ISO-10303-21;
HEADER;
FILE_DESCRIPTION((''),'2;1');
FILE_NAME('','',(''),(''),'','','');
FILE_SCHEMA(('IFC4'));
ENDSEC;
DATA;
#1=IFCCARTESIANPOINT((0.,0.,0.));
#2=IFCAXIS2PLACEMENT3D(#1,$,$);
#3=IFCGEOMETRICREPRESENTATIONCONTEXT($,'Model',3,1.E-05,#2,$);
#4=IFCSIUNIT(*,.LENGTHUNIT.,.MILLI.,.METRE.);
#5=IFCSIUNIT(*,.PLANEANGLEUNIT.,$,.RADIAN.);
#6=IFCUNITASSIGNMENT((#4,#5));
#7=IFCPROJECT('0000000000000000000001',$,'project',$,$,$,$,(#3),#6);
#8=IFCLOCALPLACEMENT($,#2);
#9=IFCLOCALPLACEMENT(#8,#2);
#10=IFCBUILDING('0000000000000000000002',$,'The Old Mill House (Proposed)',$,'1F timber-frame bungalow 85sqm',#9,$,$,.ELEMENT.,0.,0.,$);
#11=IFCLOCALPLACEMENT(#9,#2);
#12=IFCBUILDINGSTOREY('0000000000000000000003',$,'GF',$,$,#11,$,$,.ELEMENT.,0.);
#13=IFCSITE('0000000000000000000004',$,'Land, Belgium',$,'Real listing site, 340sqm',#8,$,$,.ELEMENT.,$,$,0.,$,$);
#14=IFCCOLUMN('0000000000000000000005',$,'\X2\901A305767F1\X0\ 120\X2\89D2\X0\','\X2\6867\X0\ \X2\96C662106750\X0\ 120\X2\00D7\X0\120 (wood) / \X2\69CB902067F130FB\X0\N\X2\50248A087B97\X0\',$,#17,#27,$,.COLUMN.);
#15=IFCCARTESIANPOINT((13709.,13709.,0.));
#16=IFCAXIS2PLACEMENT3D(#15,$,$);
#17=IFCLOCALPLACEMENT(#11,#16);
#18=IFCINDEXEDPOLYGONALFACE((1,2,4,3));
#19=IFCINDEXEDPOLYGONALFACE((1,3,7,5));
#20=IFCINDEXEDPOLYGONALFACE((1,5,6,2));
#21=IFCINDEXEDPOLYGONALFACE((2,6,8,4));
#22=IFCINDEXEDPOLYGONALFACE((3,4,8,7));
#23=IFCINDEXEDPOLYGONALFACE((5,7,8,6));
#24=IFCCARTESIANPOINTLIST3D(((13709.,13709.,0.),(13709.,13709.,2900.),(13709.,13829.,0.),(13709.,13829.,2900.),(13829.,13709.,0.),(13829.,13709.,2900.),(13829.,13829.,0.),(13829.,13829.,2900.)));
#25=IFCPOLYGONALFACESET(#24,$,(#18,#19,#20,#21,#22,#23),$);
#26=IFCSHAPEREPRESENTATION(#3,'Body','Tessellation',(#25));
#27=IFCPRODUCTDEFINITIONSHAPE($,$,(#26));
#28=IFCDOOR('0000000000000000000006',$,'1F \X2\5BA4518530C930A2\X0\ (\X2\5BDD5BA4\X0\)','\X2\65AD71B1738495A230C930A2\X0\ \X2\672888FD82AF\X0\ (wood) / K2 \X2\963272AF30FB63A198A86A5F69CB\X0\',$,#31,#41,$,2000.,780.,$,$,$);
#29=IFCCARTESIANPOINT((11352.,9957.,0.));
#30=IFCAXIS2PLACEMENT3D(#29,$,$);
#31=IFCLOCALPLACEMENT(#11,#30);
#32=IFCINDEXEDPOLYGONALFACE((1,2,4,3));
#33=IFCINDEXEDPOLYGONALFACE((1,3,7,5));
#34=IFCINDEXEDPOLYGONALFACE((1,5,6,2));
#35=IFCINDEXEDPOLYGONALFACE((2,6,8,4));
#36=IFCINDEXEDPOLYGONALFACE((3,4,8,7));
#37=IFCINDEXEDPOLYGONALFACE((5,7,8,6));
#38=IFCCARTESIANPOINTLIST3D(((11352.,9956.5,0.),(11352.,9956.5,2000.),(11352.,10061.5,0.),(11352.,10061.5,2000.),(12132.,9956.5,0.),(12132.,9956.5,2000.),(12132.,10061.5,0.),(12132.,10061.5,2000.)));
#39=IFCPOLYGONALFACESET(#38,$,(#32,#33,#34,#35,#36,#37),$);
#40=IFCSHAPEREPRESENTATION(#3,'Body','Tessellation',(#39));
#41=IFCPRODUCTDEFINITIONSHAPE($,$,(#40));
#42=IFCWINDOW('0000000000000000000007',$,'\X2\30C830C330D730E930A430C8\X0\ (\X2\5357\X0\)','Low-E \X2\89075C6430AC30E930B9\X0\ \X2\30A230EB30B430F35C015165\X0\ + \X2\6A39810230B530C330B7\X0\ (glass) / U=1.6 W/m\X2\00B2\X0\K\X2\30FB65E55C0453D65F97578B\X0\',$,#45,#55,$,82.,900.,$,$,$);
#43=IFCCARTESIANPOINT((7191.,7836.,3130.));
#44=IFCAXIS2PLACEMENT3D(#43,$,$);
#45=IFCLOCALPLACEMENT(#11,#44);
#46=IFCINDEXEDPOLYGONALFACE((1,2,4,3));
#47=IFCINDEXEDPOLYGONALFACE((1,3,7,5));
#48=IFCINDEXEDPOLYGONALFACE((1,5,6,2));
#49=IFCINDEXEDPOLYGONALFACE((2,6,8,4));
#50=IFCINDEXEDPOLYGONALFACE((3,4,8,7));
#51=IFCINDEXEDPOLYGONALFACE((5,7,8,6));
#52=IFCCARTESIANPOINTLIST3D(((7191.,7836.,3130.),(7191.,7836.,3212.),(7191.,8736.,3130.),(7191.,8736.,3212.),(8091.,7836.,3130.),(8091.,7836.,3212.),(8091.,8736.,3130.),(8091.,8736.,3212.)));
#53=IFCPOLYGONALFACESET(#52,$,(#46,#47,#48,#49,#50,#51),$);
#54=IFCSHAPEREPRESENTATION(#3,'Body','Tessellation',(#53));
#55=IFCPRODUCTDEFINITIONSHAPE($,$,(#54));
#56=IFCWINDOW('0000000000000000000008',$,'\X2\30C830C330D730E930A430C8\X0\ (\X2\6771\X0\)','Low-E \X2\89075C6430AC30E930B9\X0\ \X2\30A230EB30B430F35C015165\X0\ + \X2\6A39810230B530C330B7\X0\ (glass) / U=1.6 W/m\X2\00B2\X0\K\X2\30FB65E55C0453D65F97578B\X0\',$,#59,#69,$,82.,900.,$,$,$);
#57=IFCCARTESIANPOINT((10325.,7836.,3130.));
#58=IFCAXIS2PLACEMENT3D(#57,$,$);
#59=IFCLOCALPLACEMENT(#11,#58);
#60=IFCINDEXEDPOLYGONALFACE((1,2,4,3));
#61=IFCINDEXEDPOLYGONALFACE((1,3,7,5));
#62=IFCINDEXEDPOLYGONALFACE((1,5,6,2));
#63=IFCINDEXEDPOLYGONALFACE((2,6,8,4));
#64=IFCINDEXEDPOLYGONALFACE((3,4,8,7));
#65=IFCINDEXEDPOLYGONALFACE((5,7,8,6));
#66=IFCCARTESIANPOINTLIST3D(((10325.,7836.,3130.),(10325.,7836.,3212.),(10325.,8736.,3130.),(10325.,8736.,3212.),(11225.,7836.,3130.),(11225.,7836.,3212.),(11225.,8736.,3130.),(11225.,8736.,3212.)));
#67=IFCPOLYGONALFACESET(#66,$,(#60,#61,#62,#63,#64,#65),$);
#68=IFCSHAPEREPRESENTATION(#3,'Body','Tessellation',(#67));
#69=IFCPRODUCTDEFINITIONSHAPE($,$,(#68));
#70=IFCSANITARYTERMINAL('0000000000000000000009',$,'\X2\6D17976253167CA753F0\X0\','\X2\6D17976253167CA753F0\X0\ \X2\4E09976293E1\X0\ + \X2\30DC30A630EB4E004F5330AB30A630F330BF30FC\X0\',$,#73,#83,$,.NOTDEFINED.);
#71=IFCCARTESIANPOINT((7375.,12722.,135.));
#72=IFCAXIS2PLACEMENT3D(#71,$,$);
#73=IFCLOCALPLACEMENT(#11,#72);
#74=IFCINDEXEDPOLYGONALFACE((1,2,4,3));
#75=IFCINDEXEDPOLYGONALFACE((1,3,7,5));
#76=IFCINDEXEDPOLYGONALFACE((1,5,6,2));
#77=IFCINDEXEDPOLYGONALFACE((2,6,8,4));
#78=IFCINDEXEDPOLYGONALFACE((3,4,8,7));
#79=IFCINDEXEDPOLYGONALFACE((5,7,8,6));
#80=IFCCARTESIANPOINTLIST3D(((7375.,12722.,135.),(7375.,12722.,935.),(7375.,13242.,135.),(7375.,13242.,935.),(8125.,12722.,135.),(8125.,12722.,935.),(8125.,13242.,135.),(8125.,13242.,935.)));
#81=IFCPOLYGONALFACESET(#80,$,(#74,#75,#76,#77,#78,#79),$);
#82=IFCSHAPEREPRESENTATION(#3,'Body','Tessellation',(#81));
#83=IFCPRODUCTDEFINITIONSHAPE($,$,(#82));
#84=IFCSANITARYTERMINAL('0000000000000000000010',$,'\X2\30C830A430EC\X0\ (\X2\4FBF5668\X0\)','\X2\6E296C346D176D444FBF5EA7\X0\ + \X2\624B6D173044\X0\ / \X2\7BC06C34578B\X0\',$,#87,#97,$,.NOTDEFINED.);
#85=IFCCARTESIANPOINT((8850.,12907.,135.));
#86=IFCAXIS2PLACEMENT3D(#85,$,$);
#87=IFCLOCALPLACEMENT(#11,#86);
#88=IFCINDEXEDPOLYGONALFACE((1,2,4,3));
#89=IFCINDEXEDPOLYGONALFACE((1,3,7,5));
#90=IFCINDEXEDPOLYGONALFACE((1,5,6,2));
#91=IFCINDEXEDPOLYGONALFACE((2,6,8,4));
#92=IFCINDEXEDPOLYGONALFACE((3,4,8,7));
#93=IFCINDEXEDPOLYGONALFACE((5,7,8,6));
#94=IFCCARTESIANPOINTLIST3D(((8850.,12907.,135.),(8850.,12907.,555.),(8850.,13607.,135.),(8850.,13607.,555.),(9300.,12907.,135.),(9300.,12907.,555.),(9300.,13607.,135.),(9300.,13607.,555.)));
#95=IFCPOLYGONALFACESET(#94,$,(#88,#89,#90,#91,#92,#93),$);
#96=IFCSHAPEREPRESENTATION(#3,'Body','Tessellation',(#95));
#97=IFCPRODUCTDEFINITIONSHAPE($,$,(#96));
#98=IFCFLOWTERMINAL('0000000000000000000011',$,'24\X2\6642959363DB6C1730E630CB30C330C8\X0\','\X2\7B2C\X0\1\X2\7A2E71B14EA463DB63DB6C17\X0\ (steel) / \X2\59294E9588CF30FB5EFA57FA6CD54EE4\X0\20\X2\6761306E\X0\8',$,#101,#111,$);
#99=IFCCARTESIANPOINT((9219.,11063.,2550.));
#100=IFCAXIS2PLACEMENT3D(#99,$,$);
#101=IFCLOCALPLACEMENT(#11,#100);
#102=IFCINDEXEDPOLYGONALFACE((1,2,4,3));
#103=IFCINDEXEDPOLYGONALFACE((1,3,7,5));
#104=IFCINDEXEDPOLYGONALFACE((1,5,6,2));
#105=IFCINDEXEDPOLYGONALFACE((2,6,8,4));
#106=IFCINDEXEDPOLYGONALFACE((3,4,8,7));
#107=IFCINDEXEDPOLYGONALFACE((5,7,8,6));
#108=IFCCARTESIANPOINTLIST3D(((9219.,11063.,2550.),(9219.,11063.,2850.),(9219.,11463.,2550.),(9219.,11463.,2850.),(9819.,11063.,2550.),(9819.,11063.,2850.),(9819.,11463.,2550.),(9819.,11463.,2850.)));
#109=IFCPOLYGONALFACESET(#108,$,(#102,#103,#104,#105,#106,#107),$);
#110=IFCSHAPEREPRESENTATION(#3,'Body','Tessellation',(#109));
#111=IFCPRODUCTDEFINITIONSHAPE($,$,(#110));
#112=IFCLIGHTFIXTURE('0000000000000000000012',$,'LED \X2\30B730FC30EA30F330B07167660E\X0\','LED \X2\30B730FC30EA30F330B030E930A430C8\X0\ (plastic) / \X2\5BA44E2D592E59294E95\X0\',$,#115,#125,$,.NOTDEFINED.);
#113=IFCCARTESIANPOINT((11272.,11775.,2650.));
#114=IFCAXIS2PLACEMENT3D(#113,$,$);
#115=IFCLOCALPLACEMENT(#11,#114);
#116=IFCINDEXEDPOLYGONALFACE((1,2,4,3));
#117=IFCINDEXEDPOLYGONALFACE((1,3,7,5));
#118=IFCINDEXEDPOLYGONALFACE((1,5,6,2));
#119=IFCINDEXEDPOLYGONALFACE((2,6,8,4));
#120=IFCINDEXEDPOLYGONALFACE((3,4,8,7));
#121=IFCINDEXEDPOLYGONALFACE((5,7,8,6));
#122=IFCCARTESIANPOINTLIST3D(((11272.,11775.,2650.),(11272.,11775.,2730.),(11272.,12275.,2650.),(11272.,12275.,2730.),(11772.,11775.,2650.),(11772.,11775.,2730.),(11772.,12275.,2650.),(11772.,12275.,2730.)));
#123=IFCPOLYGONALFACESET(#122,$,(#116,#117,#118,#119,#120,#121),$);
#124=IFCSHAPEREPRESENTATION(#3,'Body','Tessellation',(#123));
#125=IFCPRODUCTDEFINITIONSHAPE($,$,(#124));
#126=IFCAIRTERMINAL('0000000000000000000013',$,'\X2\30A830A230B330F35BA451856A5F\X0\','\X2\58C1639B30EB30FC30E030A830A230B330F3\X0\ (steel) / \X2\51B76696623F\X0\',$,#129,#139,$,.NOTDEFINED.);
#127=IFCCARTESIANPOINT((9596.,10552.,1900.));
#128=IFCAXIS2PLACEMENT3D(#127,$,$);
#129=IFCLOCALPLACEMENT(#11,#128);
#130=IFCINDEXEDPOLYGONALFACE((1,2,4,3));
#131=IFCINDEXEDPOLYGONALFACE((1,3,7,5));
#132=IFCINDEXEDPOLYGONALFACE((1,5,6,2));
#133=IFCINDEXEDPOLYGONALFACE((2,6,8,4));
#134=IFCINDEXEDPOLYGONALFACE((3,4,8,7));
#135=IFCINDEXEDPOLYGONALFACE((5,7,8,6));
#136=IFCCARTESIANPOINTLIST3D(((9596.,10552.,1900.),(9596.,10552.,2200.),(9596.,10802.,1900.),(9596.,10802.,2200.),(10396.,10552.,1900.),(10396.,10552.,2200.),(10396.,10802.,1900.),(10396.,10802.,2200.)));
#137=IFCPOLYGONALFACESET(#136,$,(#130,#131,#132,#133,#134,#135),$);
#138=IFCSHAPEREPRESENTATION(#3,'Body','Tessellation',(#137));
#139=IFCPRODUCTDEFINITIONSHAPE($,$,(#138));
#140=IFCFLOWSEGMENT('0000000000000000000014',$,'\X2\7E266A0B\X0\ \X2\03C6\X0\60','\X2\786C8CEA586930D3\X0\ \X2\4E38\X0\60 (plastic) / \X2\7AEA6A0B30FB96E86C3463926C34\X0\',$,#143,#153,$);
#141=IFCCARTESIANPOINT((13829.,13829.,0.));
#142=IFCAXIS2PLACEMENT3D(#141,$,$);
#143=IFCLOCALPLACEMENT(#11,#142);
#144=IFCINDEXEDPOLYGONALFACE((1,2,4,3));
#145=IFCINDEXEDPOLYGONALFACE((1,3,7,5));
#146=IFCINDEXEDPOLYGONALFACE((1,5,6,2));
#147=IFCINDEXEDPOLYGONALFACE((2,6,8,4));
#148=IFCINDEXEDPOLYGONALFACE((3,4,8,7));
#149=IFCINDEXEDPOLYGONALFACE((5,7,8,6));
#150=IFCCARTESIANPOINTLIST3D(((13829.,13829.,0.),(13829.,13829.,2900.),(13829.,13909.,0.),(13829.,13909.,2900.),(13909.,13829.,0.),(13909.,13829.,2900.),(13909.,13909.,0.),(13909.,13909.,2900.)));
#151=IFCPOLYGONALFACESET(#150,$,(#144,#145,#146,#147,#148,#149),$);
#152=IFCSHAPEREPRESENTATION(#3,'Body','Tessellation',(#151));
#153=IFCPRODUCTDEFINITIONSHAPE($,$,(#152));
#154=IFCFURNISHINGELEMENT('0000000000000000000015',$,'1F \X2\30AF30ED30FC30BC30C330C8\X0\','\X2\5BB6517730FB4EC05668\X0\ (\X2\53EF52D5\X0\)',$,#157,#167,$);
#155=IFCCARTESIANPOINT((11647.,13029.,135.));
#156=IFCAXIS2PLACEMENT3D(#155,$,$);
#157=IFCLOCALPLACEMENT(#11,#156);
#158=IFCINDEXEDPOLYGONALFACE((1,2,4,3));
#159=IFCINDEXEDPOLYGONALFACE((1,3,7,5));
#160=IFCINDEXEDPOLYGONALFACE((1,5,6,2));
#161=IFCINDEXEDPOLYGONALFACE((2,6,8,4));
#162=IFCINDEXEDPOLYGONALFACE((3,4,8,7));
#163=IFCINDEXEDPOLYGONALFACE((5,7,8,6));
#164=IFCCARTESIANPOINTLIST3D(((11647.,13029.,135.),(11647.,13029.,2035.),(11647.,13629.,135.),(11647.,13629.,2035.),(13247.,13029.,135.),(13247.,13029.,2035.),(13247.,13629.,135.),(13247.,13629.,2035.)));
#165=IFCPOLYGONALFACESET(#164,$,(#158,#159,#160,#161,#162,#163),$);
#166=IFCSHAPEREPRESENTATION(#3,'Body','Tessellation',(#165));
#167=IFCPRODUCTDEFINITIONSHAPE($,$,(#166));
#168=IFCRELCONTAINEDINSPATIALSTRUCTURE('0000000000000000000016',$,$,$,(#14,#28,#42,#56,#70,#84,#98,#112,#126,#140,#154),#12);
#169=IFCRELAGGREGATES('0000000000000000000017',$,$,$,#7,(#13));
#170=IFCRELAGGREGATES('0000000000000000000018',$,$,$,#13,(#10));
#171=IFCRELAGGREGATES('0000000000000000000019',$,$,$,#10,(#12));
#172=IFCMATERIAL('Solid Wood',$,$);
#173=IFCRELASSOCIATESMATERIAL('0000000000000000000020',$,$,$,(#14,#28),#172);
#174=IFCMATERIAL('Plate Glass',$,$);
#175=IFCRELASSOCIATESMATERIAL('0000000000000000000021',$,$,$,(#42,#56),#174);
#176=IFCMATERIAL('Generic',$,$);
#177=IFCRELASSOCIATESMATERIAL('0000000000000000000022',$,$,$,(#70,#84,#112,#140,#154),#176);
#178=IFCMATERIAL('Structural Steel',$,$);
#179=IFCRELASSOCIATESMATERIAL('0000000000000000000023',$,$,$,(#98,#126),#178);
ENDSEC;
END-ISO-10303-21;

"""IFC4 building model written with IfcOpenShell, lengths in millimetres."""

from ifc_helpers import new_model, si_unit, frame, frame_2d, origin, place, context, project, spatial, rectangle, extrude, material, element, save


model = new_model("IFC4")

# Units and contexts
model_context = context("Model", 3, precision=1e-05, world=origin())
ifc_project = project(units=[si_unit("LENGTHUNIT", "METRE", prefix="MILLI"), si_unit("PLANEANGLEUNIT", "RADIAN")], contexts=[model_context])

# Site, building, storey
site_placement = place(None, origin())
site = spatial("IfcSite", under=ifc_project, at=site_placement, Name="Land, Belgium", ObjectType="Real listing site, 340sqm", CompositionType="ELEMENT", RefElevation=0.0)
building_placement = place(site_placement, origin())
building = spatial("IfcBuilding", under=site, at=building_placement, Name="The Old Mill House (Proposed)", ObjectType="1F timber-frame bungalow 85sqm", CompositionType="ELEMENT", ElevationOfRefHeight=0.0, ElevationOfTerrain=0.0)
storey_placement = place(building_placement, origin())
storey = spatial("IfcBuildingStorey", under=building, at=storey_placement, Name="GF", CompositionType="ELEMENT", Elevation=0.0)

# Column
ifc_material_1 = material(Name="Solid Wood")
column_1_placement = place(storey_placement, frame((13709.0, 13709.0, 0.0)))
element("IfcColumn", 1, at=column_1_placement, inside=storey, material=ifc_material_1, Name="通し柱 120角", Description="桧 集成材 120×120 (wood) / 構造柱・N値計算", PredefinedType="COLUMN", context=model_context, shape_type="SweptSolid", body=[
    extrude(rectangle(XDim=120.0, YDim=120.0, at=frame_2d((60.0, 60.0))), frame((13709.0, 13709.0, 0.0)), (0.0, 0.0, 1.0), 2900.0),
])

# Door
door_placement = place(storey_placement, frame((11352.0, 9957.0, 0.0)))
element("IfcDoor", 2, at=door_placement, inside=storey, material=ifc_material_1, Name="1F 室内ドア (寝室)", Description="断熱玄関ドア 木製芯 (wood) / K2 防犯・採風機構", OverallHeight=2000.0, OverallWidth=780.0, context=model_context, shape_type="SweptSolid", body=[
    extrude(rectangle(XDim=780.0, YDim=105.0, at=frame_2d((390.0, 52.0))), frame((11352.0, 9957.0, 0.0)), (0.0, 0.0, 1.0), 2000.0),
])

# Windows
ifc_material_2 = material(Name="Plate Glass")
window_1_placement = place(storey_placement, frame((7191.0, 7836.0, 3130.0)))
element("IfcWindow", 3, at=window_1_placement, inside=storey, material=ifc_material_2, Name="トップライト (南)", Description="Low-E 複層ガラス アルゴン封入 + 樹脂サッシ (glass) / U=1.6 W/m²K・日射取得型", OverallHeight=82.0, OverallWidth=900.0, context=model_context, shape_type="SweptSolid", body=[
    extrude(rectangle(XDim=900.0, YDim=900.0, at=frame_2d((450.0, 450.0))), frame((7191.0, 7836.0, 3130.0)), (0.0, 0.0, 1.0), 82.0),
])
window_2_placement = place(storey_placement, frame((10325.0, 7836.0, 3130.0)))
element("IfcWindow", 4, at=window_2_placement, inside=storey, material=ifc_material_2, Name="トップライト (東)", Description="Low-E 複層ガラス アルゴン封入 + 樹脂サッシ (glass) / U=1.6 W/m²K・日射取得型", OverallHeight=82.0, OverallWidth=900.0, context=model_context, shape_type="SweptSolid", body=[
    extrude(rectangle(XDim=900.0, YDim=900.0, at=frame_2d((450.0, 450.0))), frame((10325.0, 7836.0, 3130.0)), (0.0, 0.0, 1.0), 82.0),
])

# Sanitary terminals
ifc_material_3 = material(Name="Generic")
sanitary_terminal_1_placement = place(storey_placement, frame((7375.0, 12722.0, 135.0)))
element("IfcSanitaryTerminal", 5, at=sanitary_terminal_1_placement, inside=storey, material=ifc_material_3, Name="洗面化粧台", Description="洗面化粧台 三面鏡 + ボウル一体カウンター", PredefinedType="NOTDEFINED", context=model_context, shape_type="SweptSolid", body=[
    extrude(rectangle(XDim=750.0, YDim=520.0, at=frame_2d((375.0, 260.0))), frame((7375.0, 12722.0, 135.0)), (0.0, 0.0, 1.0), 800.0),
])
sanitary_terminal_2_placement = place(storey_placement, frame((8850.0, 12907.0, 135.0)))
element("IfcSanitaryTerminal", 6, at=sanitary_terminal_2_placement, inside=storey, material=ifc_material_3, Name="トイレ (便器)", Description="温水洗浄便座 + 手洗い / 節水型", PredefinedType="NOTDEFINED", context=model_context, shape_type="SweptSolid", body=[
    extrude(rectangle(XDim=450.0, YDim=700.0, at=frame_2d((225.0, 350.0))), frame((8850.0, 12907.0, 135.0)), (0.0, 0.0, 1.0), 420.0),
])

# Flow terminal
ifc_material_4 = material(Name="Structural Steel")
flow_terminal_placement = place(storey_placement, frame((9219.0, 11063.0, 2550.0)))
element("IfcFlowTerminal", 7, at=flow_terminal_placement, inside=storey, material=ifc_material_4, Name="24時間換気ユニット", Description="第1種熱交換換気 (steel) / 天井裏・建基法令20条の8", context=model_context, shape_type="SweptSolid", body=[
    extrude(rectangle(XDim=600.0, YDim=400.0, at=frame_2d((300.0, 200.0))), frame((9219.0, 11063.0, 2550.0)), (0.0, 0.0, 1.0), 300.0),
])

# Light fixture
light_fixture_placement = place(storey_placement, frame((11272.0, 11775.0, 2650.0)))
element("IfcLightFixture", 8, at=light_fixture_placement, inside=storey, material=ifc_material_3, Name="LED シーリング照明", Description="LED シーリングライト (plastic) / 室中央天井", PredefinedType="NOTDEFINED", context=model_context, shape_type="SweptSolid", body=[
    extrude(rectangle(XDim=500.0, YDim=500.0, at=frame_2d((250.0, 250.0))), frame((11272.0, 11775.0, 2650.0)), (0.0, 0.0, 1.0), 80.0),
])

# Air terminal
air_terminal_placement = place(storey_placement, frame((9596.0, 10552.0, 1900.0)))
element("IfcAirTerminal", 9, at=air_terminal_placement, inside=storey, material=ifc_material_4, Name="エアコン室内機", Description="壁掛ルームエアコン (steel) / 冷暖房", PredefinedType="NOTDEFINED", context=model_context, shape_type="SweptSolid", body=[
    extrude(rectangle(XDim=800.0, YDim=250.0, at=frame_2d((400.0, 125.0))), frame((9596.0, 10552.0, 1900.0)), (0.0, 0.0, 1.0), 300.0),
])

# Flow segment
flow_segment_placement = place(storey_placement, frame((13829.0, 13829.0, 0.0)))
element("IfcFlowSegment", 10, at=flow_segment_placement, inside=storey, material=ifc_material_3, Name="縦樋 φ60", Description="硬質塩ビ 丸60 (plastic) / 竪樋・雨水排水", context=model_context, shape_type="SweptSolid", body=[
    extrude(rectangle(XDim=80.0, YDim=80.0, at=frame_2d((40.0, 40.0))), frame((13829.0, 13829.0, 0.0)), (0.0, 0.0, 1.0), 2900.0),
])

# Furnishing element
furnishing_placement = place(storey_placement, frame((11647.0, 13029.0, 135.0)))
element("IfcFurnishingElement", 11, at=furnishing_placement, inside=storey, material=ifc_material_3, Name="1F クローゼット", Description="家具・什器 (可動)", context=model_context, shape_type="SweptSolid", body=[
    extrude(rectangle(XDim=1600.0, YDim=600.0, at=frame_2d((800.0, 300.0))), frame((11647.0, 13029.0, 135.0)), (0.0, 0.0, 1.0), 1900.0),
])

save(model, "model.ifc")
